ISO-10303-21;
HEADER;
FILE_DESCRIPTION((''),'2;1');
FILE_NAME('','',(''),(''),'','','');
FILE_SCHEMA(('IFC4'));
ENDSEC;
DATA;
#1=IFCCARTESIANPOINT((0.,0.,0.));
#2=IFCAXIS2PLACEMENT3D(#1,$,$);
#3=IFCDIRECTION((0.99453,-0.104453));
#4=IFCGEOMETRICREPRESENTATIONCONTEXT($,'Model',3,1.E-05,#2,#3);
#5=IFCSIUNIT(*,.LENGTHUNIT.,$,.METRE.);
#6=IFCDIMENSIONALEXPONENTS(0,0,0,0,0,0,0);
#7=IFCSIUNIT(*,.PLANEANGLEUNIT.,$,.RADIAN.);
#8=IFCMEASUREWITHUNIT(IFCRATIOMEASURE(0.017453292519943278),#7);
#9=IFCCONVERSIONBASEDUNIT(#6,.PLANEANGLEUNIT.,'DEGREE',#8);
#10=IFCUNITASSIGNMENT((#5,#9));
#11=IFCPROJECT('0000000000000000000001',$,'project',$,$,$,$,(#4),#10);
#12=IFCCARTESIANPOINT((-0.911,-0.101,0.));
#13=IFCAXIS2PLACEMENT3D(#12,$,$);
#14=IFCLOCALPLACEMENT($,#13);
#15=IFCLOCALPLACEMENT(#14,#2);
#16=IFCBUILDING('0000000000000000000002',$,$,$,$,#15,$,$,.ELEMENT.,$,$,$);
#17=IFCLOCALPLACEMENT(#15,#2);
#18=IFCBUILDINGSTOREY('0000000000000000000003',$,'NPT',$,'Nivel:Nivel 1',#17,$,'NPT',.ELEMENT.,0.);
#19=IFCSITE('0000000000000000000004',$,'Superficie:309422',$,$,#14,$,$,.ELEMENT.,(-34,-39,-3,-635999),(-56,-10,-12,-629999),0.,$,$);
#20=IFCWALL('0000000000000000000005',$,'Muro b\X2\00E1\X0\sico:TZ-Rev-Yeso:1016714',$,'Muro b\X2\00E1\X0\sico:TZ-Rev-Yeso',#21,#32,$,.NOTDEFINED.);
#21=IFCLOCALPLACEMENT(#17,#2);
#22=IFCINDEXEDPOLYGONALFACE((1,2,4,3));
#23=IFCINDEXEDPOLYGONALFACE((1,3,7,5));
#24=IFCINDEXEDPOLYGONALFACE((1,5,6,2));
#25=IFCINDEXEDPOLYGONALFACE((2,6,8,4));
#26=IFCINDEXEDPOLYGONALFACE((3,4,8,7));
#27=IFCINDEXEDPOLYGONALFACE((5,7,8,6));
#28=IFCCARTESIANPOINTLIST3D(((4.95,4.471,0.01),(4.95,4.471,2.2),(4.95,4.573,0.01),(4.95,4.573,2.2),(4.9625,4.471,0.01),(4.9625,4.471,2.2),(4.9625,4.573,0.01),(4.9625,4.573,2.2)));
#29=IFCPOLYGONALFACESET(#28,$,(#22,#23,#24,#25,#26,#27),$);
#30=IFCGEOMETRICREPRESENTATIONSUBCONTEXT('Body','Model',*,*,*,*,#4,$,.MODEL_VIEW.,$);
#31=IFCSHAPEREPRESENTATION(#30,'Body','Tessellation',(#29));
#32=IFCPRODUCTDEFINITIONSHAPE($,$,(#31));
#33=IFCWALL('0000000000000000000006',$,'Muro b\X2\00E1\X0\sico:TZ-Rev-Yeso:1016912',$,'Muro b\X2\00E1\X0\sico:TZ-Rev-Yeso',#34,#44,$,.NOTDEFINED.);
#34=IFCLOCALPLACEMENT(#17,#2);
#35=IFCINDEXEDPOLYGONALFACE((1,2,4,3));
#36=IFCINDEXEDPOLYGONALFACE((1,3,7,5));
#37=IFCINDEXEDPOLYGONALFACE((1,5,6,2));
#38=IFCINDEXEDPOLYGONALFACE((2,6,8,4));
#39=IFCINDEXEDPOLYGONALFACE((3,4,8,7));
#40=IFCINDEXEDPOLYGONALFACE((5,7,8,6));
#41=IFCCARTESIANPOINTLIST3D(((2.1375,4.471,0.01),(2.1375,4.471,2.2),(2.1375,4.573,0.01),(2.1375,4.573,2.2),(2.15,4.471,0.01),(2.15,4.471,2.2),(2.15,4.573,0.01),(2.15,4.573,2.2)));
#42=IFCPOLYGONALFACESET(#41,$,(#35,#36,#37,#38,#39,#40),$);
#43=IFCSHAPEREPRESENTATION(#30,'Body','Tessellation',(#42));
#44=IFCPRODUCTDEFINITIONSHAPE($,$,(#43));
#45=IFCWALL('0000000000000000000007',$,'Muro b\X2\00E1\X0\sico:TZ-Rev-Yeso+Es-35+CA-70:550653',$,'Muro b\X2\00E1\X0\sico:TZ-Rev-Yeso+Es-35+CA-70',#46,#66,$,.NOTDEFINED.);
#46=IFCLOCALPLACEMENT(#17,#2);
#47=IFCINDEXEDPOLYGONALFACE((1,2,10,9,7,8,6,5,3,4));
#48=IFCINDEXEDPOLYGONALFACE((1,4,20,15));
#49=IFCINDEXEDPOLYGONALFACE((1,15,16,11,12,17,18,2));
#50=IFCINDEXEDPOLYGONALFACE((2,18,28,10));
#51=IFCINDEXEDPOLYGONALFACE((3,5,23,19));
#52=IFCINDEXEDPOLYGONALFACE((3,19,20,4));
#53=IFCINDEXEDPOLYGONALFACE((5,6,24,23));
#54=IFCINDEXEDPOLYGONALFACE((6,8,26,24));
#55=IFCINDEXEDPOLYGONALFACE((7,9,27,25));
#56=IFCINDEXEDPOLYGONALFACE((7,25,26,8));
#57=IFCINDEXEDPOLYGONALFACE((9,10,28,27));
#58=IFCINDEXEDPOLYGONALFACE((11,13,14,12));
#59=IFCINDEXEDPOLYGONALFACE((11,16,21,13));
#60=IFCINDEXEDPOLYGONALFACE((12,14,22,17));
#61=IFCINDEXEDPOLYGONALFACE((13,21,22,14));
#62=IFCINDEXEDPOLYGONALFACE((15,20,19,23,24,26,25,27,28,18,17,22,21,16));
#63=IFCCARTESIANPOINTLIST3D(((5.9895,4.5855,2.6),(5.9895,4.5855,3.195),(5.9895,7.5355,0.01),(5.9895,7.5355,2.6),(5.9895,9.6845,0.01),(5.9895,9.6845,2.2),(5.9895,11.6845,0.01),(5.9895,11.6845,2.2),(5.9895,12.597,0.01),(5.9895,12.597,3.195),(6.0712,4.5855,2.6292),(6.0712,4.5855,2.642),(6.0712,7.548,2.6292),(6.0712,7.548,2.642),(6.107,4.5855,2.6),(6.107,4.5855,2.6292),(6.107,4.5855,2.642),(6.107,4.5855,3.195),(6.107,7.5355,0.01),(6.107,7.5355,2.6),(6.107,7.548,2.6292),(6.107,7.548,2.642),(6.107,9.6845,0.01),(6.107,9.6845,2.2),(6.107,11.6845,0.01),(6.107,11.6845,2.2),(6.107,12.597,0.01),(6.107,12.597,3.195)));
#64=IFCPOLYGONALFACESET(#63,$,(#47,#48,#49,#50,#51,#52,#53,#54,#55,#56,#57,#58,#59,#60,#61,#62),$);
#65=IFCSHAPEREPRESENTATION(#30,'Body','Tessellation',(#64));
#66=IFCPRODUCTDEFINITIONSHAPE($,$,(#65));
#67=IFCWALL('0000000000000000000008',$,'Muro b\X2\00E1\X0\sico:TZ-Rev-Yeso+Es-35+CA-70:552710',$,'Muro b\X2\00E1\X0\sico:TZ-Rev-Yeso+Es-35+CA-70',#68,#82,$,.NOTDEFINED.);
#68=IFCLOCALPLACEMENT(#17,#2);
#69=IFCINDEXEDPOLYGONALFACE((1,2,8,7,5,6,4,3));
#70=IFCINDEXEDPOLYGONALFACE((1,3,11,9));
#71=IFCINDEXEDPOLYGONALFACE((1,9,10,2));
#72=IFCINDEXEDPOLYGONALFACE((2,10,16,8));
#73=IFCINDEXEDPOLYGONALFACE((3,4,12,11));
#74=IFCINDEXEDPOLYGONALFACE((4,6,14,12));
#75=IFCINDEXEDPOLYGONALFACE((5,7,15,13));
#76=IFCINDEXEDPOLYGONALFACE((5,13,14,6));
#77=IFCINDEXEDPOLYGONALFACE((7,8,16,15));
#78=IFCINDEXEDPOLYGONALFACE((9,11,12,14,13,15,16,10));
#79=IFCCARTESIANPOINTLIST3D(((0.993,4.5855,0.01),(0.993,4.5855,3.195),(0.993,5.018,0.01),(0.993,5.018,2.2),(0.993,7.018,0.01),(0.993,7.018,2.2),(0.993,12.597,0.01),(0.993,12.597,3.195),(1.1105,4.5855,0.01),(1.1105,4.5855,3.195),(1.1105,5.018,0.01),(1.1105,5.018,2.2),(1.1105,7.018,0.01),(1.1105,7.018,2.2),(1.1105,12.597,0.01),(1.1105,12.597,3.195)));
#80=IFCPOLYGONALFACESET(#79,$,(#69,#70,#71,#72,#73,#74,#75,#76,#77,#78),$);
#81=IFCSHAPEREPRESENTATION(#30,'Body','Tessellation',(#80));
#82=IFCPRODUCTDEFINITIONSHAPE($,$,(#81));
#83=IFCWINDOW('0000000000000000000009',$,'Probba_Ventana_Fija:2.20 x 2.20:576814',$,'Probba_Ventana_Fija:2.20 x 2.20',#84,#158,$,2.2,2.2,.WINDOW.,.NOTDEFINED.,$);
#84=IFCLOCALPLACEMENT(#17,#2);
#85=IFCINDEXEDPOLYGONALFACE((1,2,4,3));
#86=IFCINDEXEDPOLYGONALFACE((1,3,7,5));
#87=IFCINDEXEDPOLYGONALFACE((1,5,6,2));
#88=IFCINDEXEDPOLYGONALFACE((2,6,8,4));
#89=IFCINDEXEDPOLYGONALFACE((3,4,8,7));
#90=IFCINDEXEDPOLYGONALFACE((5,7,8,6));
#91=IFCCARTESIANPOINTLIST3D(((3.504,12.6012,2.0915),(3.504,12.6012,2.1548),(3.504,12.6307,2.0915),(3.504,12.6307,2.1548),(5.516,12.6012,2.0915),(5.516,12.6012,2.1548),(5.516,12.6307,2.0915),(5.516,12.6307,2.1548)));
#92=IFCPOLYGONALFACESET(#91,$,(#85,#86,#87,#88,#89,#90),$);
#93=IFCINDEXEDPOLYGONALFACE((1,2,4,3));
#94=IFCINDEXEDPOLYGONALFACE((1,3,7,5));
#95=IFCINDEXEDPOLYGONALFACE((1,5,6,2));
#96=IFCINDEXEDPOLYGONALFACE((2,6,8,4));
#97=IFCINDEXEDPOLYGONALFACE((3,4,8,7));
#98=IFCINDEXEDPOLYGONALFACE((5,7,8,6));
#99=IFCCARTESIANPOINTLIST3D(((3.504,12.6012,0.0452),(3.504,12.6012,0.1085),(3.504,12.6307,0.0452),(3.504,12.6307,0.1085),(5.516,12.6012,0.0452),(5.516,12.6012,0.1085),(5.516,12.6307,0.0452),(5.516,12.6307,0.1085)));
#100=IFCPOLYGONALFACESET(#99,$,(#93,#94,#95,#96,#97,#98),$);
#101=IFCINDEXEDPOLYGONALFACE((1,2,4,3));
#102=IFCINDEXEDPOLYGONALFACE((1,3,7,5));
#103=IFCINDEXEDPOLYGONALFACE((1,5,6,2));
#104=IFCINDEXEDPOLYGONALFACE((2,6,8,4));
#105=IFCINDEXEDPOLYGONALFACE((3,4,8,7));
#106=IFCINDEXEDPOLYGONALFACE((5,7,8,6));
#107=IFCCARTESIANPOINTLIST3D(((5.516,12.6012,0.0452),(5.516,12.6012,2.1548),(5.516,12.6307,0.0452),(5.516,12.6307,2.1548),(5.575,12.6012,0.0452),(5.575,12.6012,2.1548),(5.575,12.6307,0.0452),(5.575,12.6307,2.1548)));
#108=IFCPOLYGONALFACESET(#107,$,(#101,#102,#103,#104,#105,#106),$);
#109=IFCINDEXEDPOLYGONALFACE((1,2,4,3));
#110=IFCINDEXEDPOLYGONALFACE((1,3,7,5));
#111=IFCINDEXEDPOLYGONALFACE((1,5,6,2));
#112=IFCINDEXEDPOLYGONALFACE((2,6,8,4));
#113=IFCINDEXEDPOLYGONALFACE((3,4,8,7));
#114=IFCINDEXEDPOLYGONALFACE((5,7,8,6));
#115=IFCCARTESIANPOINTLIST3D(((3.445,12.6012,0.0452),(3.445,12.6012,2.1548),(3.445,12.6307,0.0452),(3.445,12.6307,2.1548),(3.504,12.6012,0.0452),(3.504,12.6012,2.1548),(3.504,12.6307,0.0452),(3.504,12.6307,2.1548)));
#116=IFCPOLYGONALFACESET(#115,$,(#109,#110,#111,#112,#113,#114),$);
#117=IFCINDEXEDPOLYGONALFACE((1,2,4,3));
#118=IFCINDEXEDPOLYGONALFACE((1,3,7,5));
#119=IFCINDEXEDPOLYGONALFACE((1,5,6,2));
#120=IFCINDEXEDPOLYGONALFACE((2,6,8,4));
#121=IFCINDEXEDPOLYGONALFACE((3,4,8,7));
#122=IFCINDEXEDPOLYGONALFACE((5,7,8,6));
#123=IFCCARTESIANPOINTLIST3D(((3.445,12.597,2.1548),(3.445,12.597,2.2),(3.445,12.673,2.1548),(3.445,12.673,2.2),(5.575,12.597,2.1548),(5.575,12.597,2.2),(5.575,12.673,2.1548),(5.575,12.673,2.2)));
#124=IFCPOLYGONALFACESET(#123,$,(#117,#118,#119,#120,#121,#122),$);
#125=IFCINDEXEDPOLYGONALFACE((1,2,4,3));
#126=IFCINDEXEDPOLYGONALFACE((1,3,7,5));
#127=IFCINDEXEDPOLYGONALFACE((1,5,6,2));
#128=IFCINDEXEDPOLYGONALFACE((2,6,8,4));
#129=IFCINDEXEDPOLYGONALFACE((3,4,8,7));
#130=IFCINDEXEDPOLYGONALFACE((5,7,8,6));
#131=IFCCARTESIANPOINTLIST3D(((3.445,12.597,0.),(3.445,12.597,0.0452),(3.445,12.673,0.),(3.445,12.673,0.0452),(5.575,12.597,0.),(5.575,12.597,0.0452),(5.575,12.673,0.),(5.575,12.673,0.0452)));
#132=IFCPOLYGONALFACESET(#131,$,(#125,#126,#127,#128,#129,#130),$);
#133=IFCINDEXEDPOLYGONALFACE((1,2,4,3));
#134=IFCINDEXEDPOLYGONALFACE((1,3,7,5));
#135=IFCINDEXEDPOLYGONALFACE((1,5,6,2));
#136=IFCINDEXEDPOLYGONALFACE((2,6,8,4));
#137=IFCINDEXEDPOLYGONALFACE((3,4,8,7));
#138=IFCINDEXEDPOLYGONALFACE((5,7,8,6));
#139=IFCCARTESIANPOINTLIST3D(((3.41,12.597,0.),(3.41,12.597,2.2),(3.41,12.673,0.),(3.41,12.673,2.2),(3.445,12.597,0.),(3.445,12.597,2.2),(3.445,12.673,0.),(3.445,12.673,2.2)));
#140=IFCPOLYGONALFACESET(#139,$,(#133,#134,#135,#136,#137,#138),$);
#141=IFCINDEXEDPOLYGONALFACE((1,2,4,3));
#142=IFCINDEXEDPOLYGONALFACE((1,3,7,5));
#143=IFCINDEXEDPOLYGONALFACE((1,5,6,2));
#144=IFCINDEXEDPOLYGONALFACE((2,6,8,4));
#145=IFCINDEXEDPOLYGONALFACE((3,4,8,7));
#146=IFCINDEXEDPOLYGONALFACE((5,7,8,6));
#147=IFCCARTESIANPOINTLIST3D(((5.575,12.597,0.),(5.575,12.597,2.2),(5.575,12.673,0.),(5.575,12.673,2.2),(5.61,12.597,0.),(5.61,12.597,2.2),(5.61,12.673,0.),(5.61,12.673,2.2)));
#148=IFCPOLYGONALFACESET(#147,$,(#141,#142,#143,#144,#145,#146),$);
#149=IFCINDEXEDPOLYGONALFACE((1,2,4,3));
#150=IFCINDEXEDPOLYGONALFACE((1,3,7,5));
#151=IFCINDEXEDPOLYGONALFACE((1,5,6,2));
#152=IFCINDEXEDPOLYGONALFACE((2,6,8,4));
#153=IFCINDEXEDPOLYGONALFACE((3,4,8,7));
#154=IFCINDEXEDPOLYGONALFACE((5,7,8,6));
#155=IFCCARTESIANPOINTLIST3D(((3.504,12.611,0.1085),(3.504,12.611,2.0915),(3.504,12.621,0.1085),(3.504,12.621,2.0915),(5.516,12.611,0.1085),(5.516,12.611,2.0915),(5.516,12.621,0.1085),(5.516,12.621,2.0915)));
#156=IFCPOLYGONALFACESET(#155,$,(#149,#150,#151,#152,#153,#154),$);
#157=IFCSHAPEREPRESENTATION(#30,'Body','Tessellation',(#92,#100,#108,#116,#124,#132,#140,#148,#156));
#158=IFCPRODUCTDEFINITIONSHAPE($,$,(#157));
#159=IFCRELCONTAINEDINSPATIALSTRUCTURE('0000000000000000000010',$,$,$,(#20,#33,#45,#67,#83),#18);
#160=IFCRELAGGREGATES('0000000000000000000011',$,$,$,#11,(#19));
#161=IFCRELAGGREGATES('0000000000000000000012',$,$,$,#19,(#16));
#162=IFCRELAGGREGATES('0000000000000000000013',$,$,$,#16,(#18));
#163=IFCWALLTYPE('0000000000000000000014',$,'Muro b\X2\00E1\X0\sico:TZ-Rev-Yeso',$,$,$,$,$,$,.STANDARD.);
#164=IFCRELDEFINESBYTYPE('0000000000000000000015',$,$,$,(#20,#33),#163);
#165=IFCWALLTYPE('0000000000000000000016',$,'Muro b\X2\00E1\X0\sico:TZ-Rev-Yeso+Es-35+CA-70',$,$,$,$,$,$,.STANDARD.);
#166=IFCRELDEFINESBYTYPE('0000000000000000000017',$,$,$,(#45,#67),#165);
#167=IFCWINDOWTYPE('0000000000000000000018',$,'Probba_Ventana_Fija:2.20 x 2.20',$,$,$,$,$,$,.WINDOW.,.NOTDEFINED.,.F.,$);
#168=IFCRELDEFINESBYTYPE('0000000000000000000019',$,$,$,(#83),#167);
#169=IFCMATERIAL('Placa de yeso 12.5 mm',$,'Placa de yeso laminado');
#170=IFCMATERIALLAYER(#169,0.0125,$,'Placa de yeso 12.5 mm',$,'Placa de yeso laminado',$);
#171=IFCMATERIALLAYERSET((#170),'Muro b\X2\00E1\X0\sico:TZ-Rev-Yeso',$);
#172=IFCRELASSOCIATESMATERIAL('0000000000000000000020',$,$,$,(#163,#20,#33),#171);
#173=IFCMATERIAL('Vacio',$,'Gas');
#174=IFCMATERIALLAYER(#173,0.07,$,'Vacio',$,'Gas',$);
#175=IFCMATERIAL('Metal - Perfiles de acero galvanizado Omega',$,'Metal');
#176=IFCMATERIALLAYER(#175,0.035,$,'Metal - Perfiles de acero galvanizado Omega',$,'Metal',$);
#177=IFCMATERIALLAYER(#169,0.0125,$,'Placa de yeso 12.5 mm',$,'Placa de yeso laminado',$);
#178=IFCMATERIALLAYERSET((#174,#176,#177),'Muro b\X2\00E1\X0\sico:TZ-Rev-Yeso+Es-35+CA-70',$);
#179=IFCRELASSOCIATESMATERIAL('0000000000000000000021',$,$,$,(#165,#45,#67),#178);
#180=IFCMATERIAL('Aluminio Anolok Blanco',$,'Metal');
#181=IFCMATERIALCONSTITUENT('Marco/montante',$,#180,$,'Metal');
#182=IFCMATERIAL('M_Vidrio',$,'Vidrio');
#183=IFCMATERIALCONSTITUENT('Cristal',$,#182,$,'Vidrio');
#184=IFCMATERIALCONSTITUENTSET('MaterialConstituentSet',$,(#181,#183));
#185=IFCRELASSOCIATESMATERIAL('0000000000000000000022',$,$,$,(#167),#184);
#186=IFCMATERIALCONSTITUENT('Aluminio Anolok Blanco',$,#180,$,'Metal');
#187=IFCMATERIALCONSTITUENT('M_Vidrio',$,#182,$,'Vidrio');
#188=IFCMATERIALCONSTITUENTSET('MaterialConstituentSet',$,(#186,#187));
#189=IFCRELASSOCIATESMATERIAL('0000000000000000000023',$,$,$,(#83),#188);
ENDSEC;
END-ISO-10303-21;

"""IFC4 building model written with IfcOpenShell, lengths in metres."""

from ifc_helpers import new_model, entity, si_unit, converted_unit, direction, frame, frame_2d, origin, origin_2d_with_axis, place, context, subcontext, project, spatial, polyline, rectangle, extrude, clip, bounded_halfspace, source, transform, mapped, material, layer, layer_set, layer_usage, constituent, constituent_set, type_object, type_shapes, element, save


model = new_model("IFC4")

# Units and contexts
model_context = context("Model", 3, precision=1e-05, world=origin(), true_north=direction((0.99453, -0.104453)))
body_context = subcontext(model_context, "Body", "Model", "MODEL_VIEW")
ifc_project = project(units=[si_unit("LENGTHUNIT", "METRE"), converted_unit("PLANEANGLEUNIT", "DEGREE", entity("IfcRatioMeasure", 0.017453292519943278), si_unit("PLANEANGLEUNIT", "RADIAN"), dimensions=[0, 0, 0, 0, 0, 0, 0])], contexts=[model_context])

# Site, building, storey
site_placement = place(None, frame((-0.911, -0.101, 0.0)))
site = spatial("IfcSite", under=ifc_project, at=site_placement, Name="Superficie:309422", CompositionType="ELEMENT", RefLatitude=(-34, -39, -3, -635999), RefLongitude=(-56, -10, -12, -629999), RefElevation=0.0)
building_placement = place(site_placement, origin())
building = spatial("IfcBuilding", under=site, at=building_placement, CompositionType="ELEMENT")
storey_placement = place(building_placement, origin())
storey = spatial("IfcBuildingStorey", under=building, at=storey_placement, Name="NPT", ObjectType="Nivel:Nivel 1", LongName="NPT", CompositionType="ELEMENT", Elevation=0.0)

# Shared definitions
ifc_material_1 = material(Name="Placa de yeso 12.5 mm", Category="Placa de yeso laminado")
ifc_layer_1 = layer(ifc_material_1, 0.0125, Name="Placa de yeso 12.5 mm", Category="Placa de yeso laminado")
ifc_layer_set_1 = layer_set([ifc_layer_1], Name="Muro básico:TZ-Rev-Yeso")
wall_type_1 = type_object("IfcWallType", Name="Muro básico:TZ-Rev-Yeso", PredefinedType="STANDARD", material=ifc_layer_set_1)

# Walls
ifc_layer_usage_1 = layer_usage(ifc_layer_set_1, "AXIS2", "NEGATIVE", 0.0063)
wall_1_placement = place(storey_placement, frame((4.9563, 4.573, 0.01), z_axis=(0.0, 0.0, 1.0), x_axis=(0.0, -1.0, 0.0)))
element("IfcWall", 1, at=wall_1_placement, inside=storey, type_object=wall_type_1, material=ifc_layer_usage_1, Name="Muro básico:TZ-Rev-Yeso:1016714", ObjectType="Muro básico:TZ-Rev-Yeso", PredefinedType="NOTDEFINED", context=body_context, shape_type="Clipping", body=[
    clip(extrude(rectangle(XDim=0.102, YDim=0.0125, at=frame_2d((0.051, 0.0), x_axis=(-1.0, 0.0))), origin(), (0.0, 0.0, 1.0), 2.19), bounded_halfspace(frame((0.0, -0.0063, 2.19), z_axis=(0.0, 0.0, -1.0), x_axis=(0.0, 1.0, 0.0)), True, frame((0.0, -0.0063, 2.19), z_axis=(0.0, 0.0, -1.0), x_axis=(0.0, 1.0, 0.0)), polyline([(0.0, 0.0), (0.0038, 0.0), (0.0038, 0.0311), (0.0, 0.0311), (0.0, 0.0)]))),
])
ifc_layer_usage_2 = layer_usage(ifc_layer_set_1, "AXIS2", "POSITIVE", -0.0063)
wall_2_placement = place(storey_placement, frame((2.1438, 4.573, 0.01), z_axis=(0.0, 0.0, 1.0), x_axis=(0.0, -1.0, 0.0)))
element("IfcWall", 2, at=wall_2_placement, inside=storey, type_object=wall_type_1, material=ifc_layer_usage_2, Name="Muro básico:TZ-Rev-Yeso:1016912", ObjectType="Muro básico:TZ-Rev-Yeso", PredefinedType="NOTDEFINED", context=body_context, shape_type="Clipping", body=[
    clip(extrude(rectangle(XDim=0.102, YDim=0.0125, at=frame_2d((0.051, 0.0), x_axis=(-1.0, 0.0))), origin(), (0.0, 0.0, 1.0), 2.19), bounded_halfspace(frame((0.0, -0.0063, 2.19), z_axis=(0.0, 0.0, -1.0), x_axis=(0.0, 1.0, 0.0)), True, frame((0.0, -0.0063, 2.19), z_axis=(0.0, 0.0, -1.0), x_axis=(0.0, 1.0, 0.0)), polyline([(0.0, 0.0), (0.0038, 0.0), (0.0038, 0.0311), (0.0, 0.0311), (0.0, 0.0)]))),
])

# Wall, openings
ifc_material_2 = material(Name="Vacio", Category="Gas")
ifc_layer_2 = layer(ifc_material_2, 0.07, Name="Vacio", Category="Gas")
ifc_material_3 = material(Name="Metal - Perfiles de acero galvanizado Omega", Category="Metal")
ifc_layer_3 = layer(ifc_material_3, 0.035, Name="Metal - Perfiles de acero galvanizado Omega", Category="Metal")
ifc_layer_4 = layer(ifc_material_1, 0.0125, Name="Placa de yeso 12.5 mm", Category="Placa de yeso laminado")
ifc_layer_set_2 = layer_set([ifc_layer_2, ifc_layer_3, ifc_layer_4], Name="Muro básico:TZ-Rev-Yeso+Es-35+CA-70")
ifc_layer_usage_3 = layer_usage(ifc_layer_set_2, "AXIS2", "NEGATIVE", 0.0588)
wall_type_2 = type_object("IfcWallType", Name="Muro básico:TZ-Rev-Yeso+Es-35+CA-70", PredefinedType="STANDARD", material=ifc_layer_set_2)
wall_3_placement = place(storey_placement, frame((6.0483, 12.597, 0.01), z_axis=(0.0, 0.0, 1.0), x_axis=(0.0, -1.0, 0.0)))
wall_3 = element("IfcWall", 3, at=wall_3_placement, inside=storey, type_object=wall_type_2, material=ifc_layer_usage_3, Name="Muro básico:TZ-Rev-Yeso+Es-35+CA-70:550653", ObjectType="Muro básico:TZ-Rev-Yeso+Es-35+CA-70", PredefinedType="NOTDEFINED", context=body_context, shape_type="Clipping", body=[
    clip(extrude(rectangle(XDim=8.0115, YDim=0.1175, at=frame_2d((4.0057, 0.0), x_axis=(-1.0, 0.0))), origin(), (0.0, 0.0, 1.0), 3.185), bounded_halfspace(frame((5.049, 0.0587, 2.632), z_axis=(-1.0, 0.0, 0.0), x_axis=(0.0, 0.0, -1.0)), True, frame((5.049, 0.0587, 2.632), z_axis=(-1.0, 0.0, 0.0), x_axis=(0.0, 0.0, -1.0)), polyline([(0.0, 0.0), (0.0128, 0.0), (0.0128, 0.0358), (0.0, 0.0358), (0.0, 0.0)]))),
])
opening_1_placement = place(wall_3_placement, frame((2.9125, -1.4653, -0.01)))
element("IfcOpeningElement", 4, at=opening_1_placement, cuts=wall_3, PredefinedType="OPENING", context=body_context, shape_type="SweptSolid", body=[
    extrude(rectangle(XDim=2.2, YDim=2.0, at=frame_2d((0.0, 0.0), x_axis=(1.0, 0.0))), frame((-1.0, 0.0, 1.1), z_axis=(0.0, 1.0, 0.0), x_axis=(0.0, 0.0, 1.0)), (0.0, 0.0, 1.0), 3.048),
])
opening_2_placement = place(wall_3_placement, origin())
element("IfcOpeningElement", 5, at=opening_2_placement, cuts=wall_3, PredefinedType="OPENING", context=body_context, shape_type="SweptSolid", body=[
    extrude(rectangle(XDim=2.59, YDim=2.9562, at=frame_2d((0.0, 0.0), x_axis=(0.0, 1.0))), frame((6.5396, 0.0587, 1.295), z_axis=(0.0, -1.0, 0.0), x_axis=(1.0, 0.0, 0.0)), (0.0, 0.0, 1.0), 0.1175),
])

# Wall, opening
ifc_layer_usage_4 = layer_usage(ifc_layer_set_2, "AXIS2", "NEGATIVE", 0.0588)
wall_4_placement = place(storey_placement, frame((1.0518, 4.5855, 0.01), z_axis=(0.0, 0.0, 1.0), x_axis=(0.0, 1.0, 0.0)))
wall_4 = element("IfcWall", 6, at=wall_4_placement, inside=storey, type_object=wall_type_2, material=ifc_layer_usage_4, Name="Muro básico:TZ-Rev-Yeso+Es-35+CA-70:552710", ObjectType="Muro básico:TZ-Rev-Yeso+Es-35+CA-70", PredefinedType="NOTDEFINED", context=body_context, shape_type="SweptSolid", body=[
    extrude(rectangle(XDim=8.0115, YDim=0.1175, at=frame_2d((4.0057, 0.0), x_axis=(1.0, 0.0))), origin(), (0.0, 0.0, 1.0), 3.185),
])
opening_3_placement = place(wall_4_placement, frame((0.4325, 1.5827, -0.01)))
element("IfcOpeningElement", 7, at=opening_3_placement, cuts=wall_4, PredefinedType="OPENING", context=body_context, shape_type="SweptSolid", body=[
    extrude(rectangle(XDim=2.2, YDim=2.0, at=origin_2d_with_axis()), frame((1.0, -3.048, 1.1), z_axis=(0.0, 1.0, 0.0), x_axis=(0.0, 0.0, 1.0)), (0.0, 0.0, 1.0), 3.048),
])

# Window
ifc_material_4 = material(Name="Aluminio Anolok Blanco", Category="Metal")
ifc_constituent_1 = constituent(ifc_material_4, Name="Aluminio Anolok Blanco", Category="Metal")
ifc_material_5 = material(Name="M_Vidrio", Category="Vidrio")
ifc_constituent_2 = constituent(ifc_material_5, Name="M_Vidrio", Category="Vidrio")
ifc_constituent_set_1 = constituent_set(constituents=[ifc_constituent_1, ifc_constituent_2], Name="MaterialConstituentSet")
ifc_constituent_3 = constituent(ifc_material_4, Name="Marco/montante", Category="Metal")
ifc_constituent_4 = constituent(ifc_material_5, Name="Cristal", Category="Vidrio")
ifc_constituent_set_2 = constituent_set(constituents=[ifc_constituent_3, ifc_constituent_4], Name="MaterialConstituentSet")
window_type_1 = type_object("IfcWindowType", Name="Probba_Ventana_Fija:2.20 x 2.20", ParameterTakesPrecedence=False, PartitioningType="NOTDEFINED", PredefinedType="WINDOW", material=ifc_constituent_set_2)
shared_shape_1 = source(origin(), body_context, "Body", "SweptSolid", [
    extrude(rectangle(XDim=2.012, YDim=0.0295, at=origin_2d_with_axis()), frame((1.1, 0.019, 2.0915)), (0.0, 0.0, 1.0), 0.0633),
    extrude(rectangle(XDim=2.012, YDim=0.0295, at=origin_2d_with_axis()), frame((1.1, 0.019, 0.0452)), (0.0, 0.0, 1.0), 0.0633),
    extrude(rectangle(XDim=0.0295, YDim=0.059, at=origin_2d_with_axis()), frame((2.1355, 0.019, 0.0452), z_axis=(0.0, 0.0, 1.0), x_axis=(0.0, 1.0, 0.0)), (0.0, 0.0, 1.0), 2.1096),
    extrude(rectangle(XDim=0.0295, YDim=0.059, at=origin_2d_with_axis()), frame((0.0645, 0.019, 0.0452), z_axis=(0.0, 0.0, 1.0), x_axis=(0.0, 1.0, 0.0)), (0.0, 0.0, 1.0), 2.1096),
    extrude(rectangle(XDim=2.13, YDim=0.076, at=origin_2d_with_axis()), frame((1.1, 0.038, 2.1548)), (0.0, 0.0, 1.0), 0.0452),
    extrude(rectangle(XDim=2.13, YDim=0.076, at=origin_2d_with_axis()), frame((1.1, 0.038, 0.0)), (0.0, 0.0, 1.0), 0.0452),
    extrude(rectangle(XDim=0.035, YDim=0.076, at=origin_2d_with_axis()), frame((0.0175, 0.038, 0.0), z_axis=(0.0, 0.0, 1.0), x_axis=(-1.0, 0.0, 0.0)), (0.0, 0.0, 1.0), 2.2),
    extrude(rectangle(XDim=0.035, YDim=0.076, at=origin_2d_with_axis()), frame((2.1825, 0.038, 0.0), z_axis=(0.0, 0.0, 1.0), x_axis=(-1.0, 0.0, 0.0)), (0.0, 0.0, 1.0), 2.2),
    extrude(rectangle(XDim=0.01, YDim=2.012, at=frame_2d((0.0, 0.0), x_axis=(1.0, 0.0))), frame((1.1, 0.019, 0.1085), z_axis=(0.0, 0.0, 1.0), x_axis=(0.0, 1.0, 0.0)), (0.0, 0.0, 1.0), 1.983),
])
type_shapes(window_type_1, [shared_shape_1])
window_1_placement = place(storey_placement, frame((3.41, 12.597, 0.0)))
element("IfcWindow", 8, at=window_1_placement, inside=storey, type_object=window_type_1, material=ifc_constituent_set_1, Name="Probba_Ventana_Fija:2.20 x 2.20:576814", ObjectType="Probba_Ventana_Fija:2.20 x 2.20", OverallHeight=2.2, OverallWidth=2.2, PartitioningType="NOTDEFINED", PredefinedType="WINDOW", context=body_context, shape_type="MappedRepresentation", body=[
    mapped(shared_shape_1, transform((0.0, 0.0, 0.0), scale=1.0)),
])

save(model, "model.ifc")
